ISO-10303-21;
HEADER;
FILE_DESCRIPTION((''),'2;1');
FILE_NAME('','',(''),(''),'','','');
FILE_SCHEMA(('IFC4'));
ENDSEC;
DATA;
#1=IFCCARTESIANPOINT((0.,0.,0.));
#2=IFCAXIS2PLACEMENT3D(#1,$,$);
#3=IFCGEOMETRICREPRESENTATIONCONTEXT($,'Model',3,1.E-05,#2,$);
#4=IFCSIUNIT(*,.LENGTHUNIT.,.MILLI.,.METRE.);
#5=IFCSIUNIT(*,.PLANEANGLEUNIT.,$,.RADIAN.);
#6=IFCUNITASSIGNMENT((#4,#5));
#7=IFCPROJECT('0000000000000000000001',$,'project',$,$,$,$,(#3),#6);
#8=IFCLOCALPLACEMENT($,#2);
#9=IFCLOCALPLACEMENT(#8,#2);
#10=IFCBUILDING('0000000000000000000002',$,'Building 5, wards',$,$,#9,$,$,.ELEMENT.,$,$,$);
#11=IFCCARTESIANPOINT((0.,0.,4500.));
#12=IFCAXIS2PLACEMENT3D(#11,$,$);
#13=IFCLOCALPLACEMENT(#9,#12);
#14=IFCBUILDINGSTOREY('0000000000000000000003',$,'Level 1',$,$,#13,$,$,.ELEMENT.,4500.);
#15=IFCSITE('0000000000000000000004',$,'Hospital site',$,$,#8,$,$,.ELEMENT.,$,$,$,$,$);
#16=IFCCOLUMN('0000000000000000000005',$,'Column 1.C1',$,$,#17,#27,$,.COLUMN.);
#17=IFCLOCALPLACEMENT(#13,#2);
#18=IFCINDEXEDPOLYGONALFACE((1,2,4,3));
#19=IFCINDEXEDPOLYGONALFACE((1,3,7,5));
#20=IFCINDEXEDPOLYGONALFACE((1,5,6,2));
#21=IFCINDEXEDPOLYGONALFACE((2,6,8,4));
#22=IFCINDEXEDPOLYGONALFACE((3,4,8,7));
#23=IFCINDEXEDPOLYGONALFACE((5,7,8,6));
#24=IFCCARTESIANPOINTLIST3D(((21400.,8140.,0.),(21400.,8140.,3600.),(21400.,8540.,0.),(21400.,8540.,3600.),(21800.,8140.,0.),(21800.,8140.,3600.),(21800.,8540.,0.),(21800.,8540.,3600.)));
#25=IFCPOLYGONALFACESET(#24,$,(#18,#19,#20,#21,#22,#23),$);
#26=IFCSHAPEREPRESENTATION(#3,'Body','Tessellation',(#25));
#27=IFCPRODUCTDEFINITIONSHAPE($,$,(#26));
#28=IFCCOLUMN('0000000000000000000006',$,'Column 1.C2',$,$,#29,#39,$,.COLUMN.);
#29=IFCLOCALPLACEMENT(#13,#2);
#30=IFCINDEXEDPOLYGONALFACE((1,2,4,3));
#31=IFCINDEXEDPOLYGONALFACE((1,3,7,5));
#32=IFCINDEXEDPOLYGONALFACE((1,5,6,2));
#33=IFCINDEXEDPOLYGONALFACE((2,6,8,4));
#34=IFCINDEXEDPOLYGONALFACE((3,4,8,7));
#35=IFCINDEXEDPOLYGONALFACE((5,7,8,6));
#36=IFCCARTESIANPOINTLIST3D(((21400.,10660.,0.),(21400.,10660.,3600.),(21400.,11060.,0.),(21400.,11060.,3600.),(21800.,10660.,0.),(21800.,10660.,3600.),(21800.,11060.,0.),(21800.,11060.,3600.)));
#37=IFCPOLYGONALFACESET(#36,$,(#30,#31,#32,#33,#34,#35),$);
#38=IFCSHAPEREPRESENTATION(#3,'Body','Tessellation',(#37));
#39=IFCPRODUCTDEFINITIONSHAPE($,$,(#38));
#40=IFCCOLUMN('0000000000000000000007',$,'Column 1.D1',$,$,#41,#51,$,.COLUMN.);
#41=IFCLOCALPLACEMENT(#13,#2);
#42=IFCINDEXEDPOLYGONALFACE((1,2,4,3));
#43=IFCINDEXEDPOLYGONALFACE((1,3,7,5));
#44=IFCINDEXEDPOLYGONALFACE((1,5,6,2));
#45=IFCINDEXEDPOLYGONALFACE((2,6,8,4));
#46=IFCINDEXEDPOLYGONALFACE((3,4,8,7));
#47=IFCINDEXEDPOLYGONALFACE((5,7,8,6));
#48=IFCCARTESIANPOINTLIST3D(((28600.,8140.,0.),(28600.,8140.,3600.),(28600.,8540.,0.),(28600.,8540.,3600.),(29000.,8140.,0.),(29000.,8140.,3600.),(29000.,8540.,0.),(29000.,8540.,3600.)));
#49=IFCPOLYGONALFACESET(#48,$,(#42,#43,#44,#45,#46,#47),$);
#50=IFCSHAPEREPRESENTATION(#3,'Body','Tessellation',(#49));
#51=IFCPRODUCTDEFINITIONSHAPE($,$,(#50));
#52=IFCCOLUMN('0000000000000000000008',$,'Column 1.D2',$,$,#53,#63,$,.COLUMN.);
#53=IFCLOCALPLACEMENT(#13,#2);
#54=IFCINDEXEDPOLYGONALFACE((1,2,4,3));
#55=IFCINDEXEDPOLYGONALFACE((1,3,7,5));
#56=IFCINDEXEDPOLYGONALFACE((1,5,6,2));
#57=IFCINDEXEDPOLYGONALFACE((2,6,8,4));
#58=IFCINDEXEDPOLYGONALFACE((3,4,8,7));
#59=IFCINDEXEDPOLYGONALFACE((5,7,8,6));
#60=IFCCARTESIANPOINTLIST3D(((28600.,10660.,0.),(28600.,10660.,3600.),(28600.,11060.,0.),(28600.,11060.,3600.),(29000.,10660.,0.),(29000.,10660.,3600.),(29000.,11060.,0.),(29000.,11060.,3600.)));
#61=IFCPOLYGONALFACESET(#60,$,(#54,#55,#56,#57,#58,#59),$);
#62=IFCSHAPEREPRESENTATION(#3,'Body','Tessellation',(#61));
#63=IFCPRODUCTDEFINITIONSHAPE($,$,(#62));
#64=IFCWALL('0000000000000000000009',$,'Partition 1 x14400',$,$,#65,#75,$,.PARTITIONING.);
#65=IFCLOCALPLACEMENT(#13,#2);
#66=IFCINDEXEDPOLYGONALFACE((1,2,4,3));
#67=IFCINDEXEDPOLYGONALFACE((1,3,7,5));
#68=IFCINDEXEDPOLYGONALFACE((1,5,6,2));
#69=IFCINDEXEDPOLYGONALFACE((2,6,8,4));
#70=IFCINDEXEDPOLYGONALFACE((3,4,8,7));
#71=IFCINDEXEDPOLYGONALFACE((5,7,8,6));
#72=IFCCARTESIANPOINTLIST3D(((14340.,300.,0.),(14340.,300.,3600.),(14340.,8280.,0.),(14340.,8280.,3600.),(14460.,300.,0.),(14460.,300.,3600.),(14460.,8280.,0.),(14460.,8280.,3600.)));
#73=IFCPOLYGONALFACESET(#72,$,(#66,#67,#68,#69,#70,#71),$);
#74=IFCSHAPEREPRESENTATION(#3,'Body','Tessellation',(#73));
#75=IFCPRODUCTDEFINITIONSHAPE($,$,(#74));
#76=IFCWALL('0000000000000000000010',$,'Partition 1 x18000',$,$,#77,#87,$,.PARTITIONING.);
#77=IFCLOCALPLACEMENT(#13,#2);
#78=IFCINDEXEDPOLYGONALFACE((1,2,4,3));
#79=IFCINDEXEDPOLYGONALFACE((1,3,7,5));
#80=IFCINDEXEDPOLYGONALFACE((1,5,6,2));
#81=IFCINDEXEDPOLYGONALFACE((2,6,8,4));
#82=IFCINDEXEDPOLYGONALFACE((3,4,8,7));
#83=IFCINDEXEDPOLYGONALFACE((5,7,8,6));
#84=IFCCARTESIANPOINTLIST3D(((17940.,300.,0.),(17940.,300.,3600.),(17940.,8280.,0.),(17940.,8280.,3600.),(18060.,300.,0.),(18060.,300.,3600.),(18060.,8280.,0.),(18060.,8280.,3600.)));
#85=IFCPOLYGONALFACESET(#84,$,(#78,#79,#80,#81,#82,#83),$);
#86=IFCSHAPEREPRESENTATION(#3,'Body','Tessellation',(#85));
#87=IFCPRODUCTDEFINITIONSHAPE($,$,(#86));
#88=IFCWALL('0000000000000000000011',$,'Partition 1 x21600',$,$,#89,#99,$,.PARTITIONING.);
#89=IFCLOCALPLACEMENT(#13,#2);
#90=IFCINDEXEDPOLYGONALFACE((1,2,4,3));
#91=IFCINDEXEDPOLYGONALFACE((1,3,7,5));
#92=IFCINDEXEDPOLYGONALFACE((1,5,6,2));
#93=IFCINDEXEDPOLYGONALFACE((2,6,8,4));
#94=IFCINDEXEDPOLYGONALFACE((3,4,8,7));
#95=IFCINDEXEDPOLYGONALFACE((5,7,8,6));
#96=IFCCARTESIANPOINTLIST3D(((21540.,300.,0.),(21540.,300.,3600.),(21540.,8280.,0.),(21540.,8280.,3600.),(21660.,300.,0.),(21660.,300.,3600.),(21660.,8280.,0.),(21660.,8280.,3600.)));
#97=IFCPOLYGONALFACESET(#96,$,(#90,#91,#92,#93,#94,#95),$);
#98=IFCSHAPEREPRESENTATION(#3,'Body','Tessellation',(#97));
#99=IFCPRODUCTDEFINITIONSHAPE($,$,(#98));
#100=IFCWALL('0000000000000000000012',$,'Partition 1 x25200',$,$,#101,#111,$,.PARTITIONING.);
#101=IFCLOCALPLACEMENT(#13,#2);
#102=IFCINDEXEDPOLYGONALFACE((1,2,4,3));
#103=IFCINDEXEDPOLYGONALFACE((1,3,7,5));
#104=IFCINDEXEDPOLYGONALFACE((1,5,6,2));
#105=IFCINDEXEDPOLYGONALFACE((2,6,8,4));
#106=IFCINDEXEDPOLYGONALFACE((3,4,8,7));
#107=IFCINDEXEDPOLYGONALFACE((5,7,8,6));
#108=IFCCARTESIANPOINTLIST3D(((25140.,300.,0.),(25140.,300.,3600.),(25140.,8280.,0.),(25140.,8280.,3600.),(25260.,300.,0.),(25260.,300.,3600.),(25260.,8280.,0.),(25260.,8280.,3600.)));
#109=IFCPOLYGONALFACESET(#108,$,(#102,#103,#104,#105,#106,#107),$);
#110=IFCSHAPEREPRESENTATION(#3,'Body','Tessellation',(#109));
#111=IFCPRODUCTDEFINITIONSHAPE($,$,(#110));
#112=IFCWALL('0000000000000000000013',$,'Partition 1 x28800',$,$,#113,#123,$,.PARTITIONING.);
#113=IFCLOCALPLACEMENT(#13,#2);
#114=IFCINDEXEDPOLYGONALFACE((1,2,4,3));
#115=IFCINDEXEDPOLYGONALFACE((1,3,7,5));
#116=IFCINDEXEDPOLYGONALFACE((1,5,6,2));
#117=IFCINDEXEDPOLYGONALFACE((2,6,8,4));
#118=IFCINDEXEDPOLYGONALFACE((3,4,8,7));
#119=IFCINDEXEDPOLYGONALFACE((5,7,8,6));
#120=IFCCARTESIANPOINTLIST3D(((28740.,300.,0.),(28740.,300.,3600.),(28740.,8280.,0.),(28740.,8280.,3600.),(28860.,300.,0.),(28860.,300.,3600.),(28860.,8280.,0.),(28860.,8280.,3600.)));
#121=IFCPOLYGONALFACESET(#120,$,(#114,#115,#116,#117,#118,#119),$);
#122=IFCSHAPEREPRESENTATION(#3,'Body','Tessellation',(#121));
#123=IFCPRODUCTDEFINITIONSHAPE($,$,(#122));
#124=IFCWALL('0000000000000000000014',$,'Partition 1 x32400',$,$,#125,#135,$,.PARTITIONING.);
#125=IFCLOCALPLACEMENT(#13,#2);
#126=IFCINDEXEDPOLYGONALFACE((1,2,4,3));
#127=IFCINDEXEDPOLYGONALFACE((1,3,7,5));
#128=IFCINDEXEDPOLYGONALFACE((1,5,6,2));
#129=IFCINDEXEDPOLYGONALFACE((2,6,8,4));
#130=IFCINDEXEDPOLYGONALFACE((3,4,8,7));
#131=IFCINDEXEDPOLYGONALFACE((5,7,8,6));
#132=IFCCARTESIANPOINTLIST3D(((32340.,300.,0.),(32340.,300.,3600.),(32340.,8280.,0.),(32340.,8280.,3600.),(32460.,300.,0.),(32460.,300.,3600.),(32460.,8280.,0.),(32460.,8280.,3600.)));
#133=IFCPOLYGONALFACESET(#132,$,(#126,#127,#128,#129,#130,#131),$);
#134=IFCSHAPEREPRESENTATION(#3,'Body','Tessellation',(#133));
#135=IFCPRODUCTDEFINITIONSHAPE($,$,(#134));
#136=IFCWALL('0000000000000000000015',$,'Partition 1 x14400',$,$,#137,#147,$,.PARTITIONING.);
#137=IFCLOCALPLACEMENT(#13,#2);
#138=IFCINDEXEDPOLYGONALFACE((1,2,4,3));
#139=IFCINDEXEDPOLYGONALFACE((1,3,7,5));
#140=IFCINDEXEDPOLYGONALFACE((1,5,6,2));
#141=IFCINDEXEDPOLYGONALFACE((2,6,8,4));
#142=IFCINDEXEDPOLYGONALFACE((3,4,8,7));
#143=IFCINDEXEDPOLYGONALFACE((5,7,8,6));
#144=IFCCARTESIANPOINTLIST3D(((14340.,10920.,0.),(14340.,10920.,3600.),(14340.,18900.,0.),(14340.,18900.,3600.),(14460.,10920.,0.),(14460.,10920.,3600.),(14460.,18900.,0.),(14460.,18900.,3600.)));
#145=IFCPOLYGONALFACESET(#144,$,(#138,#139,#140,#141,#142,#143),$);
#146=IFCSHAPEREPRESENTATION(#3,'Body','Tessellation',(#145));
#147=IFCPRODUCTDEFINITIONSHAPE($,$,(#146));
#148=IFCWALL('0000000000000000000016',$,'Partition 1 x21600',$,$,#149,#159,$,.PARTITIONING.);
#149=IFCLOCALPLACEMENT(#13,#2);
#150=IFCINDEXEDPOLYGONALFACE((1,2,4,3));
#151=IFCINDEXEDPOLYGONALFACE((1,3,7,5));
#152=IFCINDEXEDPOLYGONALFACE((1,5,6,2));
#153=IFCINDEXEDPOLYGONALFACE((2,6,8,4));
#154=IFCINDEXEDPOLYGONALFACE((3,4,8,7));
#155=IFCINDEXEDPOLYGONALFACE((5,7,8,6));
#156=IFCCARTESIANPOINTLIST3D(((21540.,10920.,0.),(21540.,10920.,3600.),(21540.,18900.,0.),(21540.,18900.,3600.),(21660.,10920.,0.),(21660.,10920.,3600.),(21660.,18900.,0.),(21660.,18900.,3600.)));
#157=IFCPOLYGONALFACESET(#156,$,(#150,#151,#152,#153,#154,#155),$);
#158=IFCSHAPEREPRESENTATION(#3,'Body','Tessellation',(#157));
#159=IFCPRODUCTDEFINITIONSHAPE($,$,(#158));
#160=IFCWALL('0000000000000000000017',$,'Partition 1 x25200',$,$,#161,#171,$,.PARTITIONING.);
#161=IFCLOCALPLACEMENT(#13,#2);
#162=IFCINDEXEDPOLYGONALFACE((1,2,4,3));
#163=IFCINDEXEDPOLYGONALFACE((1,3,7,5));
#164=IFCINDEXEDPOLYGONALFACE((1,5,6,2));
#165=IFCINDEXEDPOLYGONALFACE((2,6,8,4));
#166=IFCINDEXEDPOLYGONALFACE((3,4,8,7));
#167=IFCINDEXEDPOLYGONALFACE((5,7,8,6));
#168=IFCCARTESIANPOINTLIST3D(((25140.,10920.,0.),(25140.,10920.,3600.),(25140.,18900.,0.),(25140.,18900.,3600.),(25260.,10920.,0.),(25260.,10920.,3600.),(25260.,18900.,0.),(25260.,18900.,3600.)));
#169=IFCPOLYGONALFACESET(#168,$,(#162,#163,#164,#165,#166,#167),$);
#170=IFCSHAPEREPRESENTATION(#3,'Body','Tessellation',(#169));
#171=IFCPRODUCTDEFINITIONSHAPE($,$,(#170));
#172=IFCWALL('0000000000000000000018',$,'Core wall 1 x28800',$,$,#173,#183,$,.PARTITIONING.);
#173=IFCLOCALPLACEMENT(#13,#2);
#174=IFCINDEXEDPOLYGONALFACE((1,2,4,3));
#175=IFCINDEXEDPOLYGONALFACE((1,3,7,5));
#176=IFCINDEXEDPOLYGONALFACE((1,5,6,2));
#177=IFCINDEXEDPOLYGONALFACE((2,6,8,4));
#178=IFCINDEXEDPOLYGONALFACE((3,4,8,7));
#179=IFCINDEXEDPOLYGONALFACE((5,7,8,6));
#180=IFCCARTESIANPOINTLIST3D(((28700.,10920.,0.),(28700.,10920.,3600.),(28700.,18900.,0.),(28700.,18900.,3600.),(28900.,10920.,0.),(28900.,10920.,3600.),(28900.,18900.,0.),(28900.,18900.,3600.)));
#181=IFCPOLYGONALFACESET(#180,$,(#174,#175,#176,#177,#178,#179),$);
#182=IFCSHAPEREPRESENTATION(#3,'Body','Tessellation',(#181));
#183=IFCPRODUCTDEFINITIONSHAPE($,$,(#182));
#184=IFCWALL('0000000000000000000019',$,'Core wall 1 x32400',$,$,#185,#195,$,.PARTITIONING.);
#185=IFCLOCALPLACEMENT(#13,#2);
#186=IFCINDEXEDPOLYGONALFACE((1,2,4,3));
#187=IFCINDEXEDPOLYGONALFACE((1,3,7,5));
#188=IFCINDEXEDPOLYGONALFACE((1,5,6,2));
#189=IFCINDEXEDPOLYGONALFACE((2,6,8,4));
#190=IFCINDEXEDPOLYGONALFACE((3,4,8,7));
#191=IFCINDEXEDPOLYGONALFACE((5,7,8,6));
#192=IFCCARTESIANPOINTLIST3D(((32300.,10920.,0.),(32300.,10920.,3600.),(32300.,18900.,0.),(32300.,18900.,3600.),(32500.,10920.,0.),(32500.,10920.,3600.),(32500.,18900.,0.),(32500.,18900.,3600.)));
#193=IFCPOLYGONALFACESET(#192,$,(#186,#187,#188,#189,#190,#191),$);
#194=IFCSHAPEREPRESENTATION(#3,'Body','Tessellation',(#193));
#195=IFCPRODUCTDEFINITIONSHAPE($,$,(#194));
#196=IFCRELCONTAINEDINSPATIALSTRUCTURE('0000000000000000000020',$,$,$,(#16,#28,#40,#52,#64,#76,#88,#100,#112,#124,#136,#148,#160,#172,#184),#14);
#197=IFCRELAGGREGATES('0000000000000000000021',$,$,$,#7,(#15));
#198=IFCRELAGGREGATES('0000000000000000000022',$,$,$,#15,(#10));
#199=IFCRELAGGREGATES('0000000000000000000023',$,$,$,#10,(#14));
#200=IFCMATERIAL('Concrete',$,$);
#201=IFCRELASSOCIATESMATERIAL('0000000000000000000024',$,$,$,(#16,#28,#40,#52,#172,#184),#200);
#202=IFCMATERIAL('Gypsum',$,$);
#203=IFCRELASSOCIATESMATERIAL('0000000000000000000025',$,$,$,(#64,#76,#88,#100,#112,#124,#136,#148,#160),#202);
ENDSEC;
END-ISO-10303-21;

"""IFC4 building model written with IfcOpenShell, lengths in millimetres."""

from ifc_helpers import new_model, si_unit, frame, frame_2d, origin, origin_2d, place, context, project, spatial, rectangle, extrude, material, element, save


model = new_model("IFC4")

# Units and contexts
model_context = context("Model", 3, precision=1e-05, world=origin())
ifc_project = project(units=[si_unit("LENGTHUNIT", "METRE", prefix="MILLI"), si_unit("PLANEANGLEUNIT", "RADIAN")], contexts=[model_context])

# Site, building, storey
site_placement = place(None, origin())
site = spatial("IfcSite", under=ifc_project, at=site_placement, Name="Hospital site", CompositionType="ELEMENT")
building_placement = place(site_placement, origin())
building = spatial("IfcBuilding", under=site, at=building_placement, Name="Building 5, wards", CompositionType="ELEMENT")
storey_placement = place(building_placement, frame((0.0, 0.0, 4500.0)))
storey = spatial("IfcBuildingStorey", under=building, at=storey_placement, Name="Level 1", CompositionType="ELEMENT", Elevation=4500.0)

# Columns
ifc_material_1 = material(Name="Concrete")
for number, where, name in (
    (1, (21600.0, 8340.0, 0.0), "Column 1.C1"),
    (2, (21600.0, 10860.0, 0.0), "Column 1.C2"),
    (3, (28800.0, 8340.0, 0.0), "Column 1.D1"),
    (4, (28800.0, 10860.0, 0.0), "Column 1.D2"),
):
    element("IfcColumn", number, at=place(storey_placement, frame(where)), inside=storey, material=ifc_material_1, Name=name, PredefinedType="COLUMN", context=model_context, shape_type="SweptSolid", body=[
        extrude(rectangle(XDim=400.0, YDim=400.0, at=origin_2d()), origin(), (0.0, 0.0, 1.0), 3600.0),
    ])

# Walls
ifc_material_2 = material(Name="Gypsum")
for number, where, x_axis, name in (
    (5, (14460.0, 300.0, 0.0), (0.0, 1.0, 0.0), "Partition 1 x14400"),
    (6, (18060.0, 300.0, 0.0), (0.0, 1.0, 0.0), "Partition 1 x18000"),
    (7, (21660.0, 300.0, 0.0), (0.0, 1.0, 0.0), "Partition 1 x21600"),
    (8, (25260.0, 300.0, 0.0), (0.0, 1.0, 0.0), "Partition 1 x25200"),
    (9, (28860.0, 300.0, 0.0), (0.0, 1.0, 0.0), "Partition 1 x28800"),
    (10, (32460.0, 300.0, 0.0), (0.0, 1.0, 0.0), "Partition 1 x32400"),
    (11, (14460.0, 10920.0, 0.0), (0.0, 1.0, 0.0), "Partition 1 x14400"),
    (12, (21660.0, 10920.0, 0.0), (0.0, 1.0, 0.0), "Partition 1 x21600"),
    (13, (25260.0, 10920.0, 0.0), (0.0, 1.0, 0.0), "Partition 1 x25200"),
):
    element("IfcWall", number, at=place(storey_placement, frame(where, x_axis=x_axis)), inside=storey, material=ifc_material_2, Name=name, PredefinedType="PARTITIONING", context=model_context, shape_type="SweptSolid", body=[
        extrude(rectangle(XDim=7980.0, YDim=120.0, at=frame_2d((3990.0, 60.0))), origin(), (0.0, 0.0, 1.0), 3600.0),
    ])
for number, where, x_axis, name in (
    (14, (28900.0, 10920.0, 0.0), (0.0, 1.0, 0.0), "Core wall 1 x28800"),
    (15, (32500.0, 10920.0, 0.0), (0.0, 1.0, 0.0), "Core wall 1 x32400"),
):
    element("IfcWall", number, at=place(storey_placement, frame(where, x_axis=x_axis)), inside=storey, material=ifc_material_1, Name=name, PredefinedType="PARTITIONING", context=model_context, shape_type="SweptSolid", body=[
        extrude(rectangle(XDim=7980.0, YDim=200.0, at=frame_2d((3990.0, 100.0))), origin(), (0.0, 0.0, 1.0), 3600.0),
    ])

save(model, "model.ifc")
